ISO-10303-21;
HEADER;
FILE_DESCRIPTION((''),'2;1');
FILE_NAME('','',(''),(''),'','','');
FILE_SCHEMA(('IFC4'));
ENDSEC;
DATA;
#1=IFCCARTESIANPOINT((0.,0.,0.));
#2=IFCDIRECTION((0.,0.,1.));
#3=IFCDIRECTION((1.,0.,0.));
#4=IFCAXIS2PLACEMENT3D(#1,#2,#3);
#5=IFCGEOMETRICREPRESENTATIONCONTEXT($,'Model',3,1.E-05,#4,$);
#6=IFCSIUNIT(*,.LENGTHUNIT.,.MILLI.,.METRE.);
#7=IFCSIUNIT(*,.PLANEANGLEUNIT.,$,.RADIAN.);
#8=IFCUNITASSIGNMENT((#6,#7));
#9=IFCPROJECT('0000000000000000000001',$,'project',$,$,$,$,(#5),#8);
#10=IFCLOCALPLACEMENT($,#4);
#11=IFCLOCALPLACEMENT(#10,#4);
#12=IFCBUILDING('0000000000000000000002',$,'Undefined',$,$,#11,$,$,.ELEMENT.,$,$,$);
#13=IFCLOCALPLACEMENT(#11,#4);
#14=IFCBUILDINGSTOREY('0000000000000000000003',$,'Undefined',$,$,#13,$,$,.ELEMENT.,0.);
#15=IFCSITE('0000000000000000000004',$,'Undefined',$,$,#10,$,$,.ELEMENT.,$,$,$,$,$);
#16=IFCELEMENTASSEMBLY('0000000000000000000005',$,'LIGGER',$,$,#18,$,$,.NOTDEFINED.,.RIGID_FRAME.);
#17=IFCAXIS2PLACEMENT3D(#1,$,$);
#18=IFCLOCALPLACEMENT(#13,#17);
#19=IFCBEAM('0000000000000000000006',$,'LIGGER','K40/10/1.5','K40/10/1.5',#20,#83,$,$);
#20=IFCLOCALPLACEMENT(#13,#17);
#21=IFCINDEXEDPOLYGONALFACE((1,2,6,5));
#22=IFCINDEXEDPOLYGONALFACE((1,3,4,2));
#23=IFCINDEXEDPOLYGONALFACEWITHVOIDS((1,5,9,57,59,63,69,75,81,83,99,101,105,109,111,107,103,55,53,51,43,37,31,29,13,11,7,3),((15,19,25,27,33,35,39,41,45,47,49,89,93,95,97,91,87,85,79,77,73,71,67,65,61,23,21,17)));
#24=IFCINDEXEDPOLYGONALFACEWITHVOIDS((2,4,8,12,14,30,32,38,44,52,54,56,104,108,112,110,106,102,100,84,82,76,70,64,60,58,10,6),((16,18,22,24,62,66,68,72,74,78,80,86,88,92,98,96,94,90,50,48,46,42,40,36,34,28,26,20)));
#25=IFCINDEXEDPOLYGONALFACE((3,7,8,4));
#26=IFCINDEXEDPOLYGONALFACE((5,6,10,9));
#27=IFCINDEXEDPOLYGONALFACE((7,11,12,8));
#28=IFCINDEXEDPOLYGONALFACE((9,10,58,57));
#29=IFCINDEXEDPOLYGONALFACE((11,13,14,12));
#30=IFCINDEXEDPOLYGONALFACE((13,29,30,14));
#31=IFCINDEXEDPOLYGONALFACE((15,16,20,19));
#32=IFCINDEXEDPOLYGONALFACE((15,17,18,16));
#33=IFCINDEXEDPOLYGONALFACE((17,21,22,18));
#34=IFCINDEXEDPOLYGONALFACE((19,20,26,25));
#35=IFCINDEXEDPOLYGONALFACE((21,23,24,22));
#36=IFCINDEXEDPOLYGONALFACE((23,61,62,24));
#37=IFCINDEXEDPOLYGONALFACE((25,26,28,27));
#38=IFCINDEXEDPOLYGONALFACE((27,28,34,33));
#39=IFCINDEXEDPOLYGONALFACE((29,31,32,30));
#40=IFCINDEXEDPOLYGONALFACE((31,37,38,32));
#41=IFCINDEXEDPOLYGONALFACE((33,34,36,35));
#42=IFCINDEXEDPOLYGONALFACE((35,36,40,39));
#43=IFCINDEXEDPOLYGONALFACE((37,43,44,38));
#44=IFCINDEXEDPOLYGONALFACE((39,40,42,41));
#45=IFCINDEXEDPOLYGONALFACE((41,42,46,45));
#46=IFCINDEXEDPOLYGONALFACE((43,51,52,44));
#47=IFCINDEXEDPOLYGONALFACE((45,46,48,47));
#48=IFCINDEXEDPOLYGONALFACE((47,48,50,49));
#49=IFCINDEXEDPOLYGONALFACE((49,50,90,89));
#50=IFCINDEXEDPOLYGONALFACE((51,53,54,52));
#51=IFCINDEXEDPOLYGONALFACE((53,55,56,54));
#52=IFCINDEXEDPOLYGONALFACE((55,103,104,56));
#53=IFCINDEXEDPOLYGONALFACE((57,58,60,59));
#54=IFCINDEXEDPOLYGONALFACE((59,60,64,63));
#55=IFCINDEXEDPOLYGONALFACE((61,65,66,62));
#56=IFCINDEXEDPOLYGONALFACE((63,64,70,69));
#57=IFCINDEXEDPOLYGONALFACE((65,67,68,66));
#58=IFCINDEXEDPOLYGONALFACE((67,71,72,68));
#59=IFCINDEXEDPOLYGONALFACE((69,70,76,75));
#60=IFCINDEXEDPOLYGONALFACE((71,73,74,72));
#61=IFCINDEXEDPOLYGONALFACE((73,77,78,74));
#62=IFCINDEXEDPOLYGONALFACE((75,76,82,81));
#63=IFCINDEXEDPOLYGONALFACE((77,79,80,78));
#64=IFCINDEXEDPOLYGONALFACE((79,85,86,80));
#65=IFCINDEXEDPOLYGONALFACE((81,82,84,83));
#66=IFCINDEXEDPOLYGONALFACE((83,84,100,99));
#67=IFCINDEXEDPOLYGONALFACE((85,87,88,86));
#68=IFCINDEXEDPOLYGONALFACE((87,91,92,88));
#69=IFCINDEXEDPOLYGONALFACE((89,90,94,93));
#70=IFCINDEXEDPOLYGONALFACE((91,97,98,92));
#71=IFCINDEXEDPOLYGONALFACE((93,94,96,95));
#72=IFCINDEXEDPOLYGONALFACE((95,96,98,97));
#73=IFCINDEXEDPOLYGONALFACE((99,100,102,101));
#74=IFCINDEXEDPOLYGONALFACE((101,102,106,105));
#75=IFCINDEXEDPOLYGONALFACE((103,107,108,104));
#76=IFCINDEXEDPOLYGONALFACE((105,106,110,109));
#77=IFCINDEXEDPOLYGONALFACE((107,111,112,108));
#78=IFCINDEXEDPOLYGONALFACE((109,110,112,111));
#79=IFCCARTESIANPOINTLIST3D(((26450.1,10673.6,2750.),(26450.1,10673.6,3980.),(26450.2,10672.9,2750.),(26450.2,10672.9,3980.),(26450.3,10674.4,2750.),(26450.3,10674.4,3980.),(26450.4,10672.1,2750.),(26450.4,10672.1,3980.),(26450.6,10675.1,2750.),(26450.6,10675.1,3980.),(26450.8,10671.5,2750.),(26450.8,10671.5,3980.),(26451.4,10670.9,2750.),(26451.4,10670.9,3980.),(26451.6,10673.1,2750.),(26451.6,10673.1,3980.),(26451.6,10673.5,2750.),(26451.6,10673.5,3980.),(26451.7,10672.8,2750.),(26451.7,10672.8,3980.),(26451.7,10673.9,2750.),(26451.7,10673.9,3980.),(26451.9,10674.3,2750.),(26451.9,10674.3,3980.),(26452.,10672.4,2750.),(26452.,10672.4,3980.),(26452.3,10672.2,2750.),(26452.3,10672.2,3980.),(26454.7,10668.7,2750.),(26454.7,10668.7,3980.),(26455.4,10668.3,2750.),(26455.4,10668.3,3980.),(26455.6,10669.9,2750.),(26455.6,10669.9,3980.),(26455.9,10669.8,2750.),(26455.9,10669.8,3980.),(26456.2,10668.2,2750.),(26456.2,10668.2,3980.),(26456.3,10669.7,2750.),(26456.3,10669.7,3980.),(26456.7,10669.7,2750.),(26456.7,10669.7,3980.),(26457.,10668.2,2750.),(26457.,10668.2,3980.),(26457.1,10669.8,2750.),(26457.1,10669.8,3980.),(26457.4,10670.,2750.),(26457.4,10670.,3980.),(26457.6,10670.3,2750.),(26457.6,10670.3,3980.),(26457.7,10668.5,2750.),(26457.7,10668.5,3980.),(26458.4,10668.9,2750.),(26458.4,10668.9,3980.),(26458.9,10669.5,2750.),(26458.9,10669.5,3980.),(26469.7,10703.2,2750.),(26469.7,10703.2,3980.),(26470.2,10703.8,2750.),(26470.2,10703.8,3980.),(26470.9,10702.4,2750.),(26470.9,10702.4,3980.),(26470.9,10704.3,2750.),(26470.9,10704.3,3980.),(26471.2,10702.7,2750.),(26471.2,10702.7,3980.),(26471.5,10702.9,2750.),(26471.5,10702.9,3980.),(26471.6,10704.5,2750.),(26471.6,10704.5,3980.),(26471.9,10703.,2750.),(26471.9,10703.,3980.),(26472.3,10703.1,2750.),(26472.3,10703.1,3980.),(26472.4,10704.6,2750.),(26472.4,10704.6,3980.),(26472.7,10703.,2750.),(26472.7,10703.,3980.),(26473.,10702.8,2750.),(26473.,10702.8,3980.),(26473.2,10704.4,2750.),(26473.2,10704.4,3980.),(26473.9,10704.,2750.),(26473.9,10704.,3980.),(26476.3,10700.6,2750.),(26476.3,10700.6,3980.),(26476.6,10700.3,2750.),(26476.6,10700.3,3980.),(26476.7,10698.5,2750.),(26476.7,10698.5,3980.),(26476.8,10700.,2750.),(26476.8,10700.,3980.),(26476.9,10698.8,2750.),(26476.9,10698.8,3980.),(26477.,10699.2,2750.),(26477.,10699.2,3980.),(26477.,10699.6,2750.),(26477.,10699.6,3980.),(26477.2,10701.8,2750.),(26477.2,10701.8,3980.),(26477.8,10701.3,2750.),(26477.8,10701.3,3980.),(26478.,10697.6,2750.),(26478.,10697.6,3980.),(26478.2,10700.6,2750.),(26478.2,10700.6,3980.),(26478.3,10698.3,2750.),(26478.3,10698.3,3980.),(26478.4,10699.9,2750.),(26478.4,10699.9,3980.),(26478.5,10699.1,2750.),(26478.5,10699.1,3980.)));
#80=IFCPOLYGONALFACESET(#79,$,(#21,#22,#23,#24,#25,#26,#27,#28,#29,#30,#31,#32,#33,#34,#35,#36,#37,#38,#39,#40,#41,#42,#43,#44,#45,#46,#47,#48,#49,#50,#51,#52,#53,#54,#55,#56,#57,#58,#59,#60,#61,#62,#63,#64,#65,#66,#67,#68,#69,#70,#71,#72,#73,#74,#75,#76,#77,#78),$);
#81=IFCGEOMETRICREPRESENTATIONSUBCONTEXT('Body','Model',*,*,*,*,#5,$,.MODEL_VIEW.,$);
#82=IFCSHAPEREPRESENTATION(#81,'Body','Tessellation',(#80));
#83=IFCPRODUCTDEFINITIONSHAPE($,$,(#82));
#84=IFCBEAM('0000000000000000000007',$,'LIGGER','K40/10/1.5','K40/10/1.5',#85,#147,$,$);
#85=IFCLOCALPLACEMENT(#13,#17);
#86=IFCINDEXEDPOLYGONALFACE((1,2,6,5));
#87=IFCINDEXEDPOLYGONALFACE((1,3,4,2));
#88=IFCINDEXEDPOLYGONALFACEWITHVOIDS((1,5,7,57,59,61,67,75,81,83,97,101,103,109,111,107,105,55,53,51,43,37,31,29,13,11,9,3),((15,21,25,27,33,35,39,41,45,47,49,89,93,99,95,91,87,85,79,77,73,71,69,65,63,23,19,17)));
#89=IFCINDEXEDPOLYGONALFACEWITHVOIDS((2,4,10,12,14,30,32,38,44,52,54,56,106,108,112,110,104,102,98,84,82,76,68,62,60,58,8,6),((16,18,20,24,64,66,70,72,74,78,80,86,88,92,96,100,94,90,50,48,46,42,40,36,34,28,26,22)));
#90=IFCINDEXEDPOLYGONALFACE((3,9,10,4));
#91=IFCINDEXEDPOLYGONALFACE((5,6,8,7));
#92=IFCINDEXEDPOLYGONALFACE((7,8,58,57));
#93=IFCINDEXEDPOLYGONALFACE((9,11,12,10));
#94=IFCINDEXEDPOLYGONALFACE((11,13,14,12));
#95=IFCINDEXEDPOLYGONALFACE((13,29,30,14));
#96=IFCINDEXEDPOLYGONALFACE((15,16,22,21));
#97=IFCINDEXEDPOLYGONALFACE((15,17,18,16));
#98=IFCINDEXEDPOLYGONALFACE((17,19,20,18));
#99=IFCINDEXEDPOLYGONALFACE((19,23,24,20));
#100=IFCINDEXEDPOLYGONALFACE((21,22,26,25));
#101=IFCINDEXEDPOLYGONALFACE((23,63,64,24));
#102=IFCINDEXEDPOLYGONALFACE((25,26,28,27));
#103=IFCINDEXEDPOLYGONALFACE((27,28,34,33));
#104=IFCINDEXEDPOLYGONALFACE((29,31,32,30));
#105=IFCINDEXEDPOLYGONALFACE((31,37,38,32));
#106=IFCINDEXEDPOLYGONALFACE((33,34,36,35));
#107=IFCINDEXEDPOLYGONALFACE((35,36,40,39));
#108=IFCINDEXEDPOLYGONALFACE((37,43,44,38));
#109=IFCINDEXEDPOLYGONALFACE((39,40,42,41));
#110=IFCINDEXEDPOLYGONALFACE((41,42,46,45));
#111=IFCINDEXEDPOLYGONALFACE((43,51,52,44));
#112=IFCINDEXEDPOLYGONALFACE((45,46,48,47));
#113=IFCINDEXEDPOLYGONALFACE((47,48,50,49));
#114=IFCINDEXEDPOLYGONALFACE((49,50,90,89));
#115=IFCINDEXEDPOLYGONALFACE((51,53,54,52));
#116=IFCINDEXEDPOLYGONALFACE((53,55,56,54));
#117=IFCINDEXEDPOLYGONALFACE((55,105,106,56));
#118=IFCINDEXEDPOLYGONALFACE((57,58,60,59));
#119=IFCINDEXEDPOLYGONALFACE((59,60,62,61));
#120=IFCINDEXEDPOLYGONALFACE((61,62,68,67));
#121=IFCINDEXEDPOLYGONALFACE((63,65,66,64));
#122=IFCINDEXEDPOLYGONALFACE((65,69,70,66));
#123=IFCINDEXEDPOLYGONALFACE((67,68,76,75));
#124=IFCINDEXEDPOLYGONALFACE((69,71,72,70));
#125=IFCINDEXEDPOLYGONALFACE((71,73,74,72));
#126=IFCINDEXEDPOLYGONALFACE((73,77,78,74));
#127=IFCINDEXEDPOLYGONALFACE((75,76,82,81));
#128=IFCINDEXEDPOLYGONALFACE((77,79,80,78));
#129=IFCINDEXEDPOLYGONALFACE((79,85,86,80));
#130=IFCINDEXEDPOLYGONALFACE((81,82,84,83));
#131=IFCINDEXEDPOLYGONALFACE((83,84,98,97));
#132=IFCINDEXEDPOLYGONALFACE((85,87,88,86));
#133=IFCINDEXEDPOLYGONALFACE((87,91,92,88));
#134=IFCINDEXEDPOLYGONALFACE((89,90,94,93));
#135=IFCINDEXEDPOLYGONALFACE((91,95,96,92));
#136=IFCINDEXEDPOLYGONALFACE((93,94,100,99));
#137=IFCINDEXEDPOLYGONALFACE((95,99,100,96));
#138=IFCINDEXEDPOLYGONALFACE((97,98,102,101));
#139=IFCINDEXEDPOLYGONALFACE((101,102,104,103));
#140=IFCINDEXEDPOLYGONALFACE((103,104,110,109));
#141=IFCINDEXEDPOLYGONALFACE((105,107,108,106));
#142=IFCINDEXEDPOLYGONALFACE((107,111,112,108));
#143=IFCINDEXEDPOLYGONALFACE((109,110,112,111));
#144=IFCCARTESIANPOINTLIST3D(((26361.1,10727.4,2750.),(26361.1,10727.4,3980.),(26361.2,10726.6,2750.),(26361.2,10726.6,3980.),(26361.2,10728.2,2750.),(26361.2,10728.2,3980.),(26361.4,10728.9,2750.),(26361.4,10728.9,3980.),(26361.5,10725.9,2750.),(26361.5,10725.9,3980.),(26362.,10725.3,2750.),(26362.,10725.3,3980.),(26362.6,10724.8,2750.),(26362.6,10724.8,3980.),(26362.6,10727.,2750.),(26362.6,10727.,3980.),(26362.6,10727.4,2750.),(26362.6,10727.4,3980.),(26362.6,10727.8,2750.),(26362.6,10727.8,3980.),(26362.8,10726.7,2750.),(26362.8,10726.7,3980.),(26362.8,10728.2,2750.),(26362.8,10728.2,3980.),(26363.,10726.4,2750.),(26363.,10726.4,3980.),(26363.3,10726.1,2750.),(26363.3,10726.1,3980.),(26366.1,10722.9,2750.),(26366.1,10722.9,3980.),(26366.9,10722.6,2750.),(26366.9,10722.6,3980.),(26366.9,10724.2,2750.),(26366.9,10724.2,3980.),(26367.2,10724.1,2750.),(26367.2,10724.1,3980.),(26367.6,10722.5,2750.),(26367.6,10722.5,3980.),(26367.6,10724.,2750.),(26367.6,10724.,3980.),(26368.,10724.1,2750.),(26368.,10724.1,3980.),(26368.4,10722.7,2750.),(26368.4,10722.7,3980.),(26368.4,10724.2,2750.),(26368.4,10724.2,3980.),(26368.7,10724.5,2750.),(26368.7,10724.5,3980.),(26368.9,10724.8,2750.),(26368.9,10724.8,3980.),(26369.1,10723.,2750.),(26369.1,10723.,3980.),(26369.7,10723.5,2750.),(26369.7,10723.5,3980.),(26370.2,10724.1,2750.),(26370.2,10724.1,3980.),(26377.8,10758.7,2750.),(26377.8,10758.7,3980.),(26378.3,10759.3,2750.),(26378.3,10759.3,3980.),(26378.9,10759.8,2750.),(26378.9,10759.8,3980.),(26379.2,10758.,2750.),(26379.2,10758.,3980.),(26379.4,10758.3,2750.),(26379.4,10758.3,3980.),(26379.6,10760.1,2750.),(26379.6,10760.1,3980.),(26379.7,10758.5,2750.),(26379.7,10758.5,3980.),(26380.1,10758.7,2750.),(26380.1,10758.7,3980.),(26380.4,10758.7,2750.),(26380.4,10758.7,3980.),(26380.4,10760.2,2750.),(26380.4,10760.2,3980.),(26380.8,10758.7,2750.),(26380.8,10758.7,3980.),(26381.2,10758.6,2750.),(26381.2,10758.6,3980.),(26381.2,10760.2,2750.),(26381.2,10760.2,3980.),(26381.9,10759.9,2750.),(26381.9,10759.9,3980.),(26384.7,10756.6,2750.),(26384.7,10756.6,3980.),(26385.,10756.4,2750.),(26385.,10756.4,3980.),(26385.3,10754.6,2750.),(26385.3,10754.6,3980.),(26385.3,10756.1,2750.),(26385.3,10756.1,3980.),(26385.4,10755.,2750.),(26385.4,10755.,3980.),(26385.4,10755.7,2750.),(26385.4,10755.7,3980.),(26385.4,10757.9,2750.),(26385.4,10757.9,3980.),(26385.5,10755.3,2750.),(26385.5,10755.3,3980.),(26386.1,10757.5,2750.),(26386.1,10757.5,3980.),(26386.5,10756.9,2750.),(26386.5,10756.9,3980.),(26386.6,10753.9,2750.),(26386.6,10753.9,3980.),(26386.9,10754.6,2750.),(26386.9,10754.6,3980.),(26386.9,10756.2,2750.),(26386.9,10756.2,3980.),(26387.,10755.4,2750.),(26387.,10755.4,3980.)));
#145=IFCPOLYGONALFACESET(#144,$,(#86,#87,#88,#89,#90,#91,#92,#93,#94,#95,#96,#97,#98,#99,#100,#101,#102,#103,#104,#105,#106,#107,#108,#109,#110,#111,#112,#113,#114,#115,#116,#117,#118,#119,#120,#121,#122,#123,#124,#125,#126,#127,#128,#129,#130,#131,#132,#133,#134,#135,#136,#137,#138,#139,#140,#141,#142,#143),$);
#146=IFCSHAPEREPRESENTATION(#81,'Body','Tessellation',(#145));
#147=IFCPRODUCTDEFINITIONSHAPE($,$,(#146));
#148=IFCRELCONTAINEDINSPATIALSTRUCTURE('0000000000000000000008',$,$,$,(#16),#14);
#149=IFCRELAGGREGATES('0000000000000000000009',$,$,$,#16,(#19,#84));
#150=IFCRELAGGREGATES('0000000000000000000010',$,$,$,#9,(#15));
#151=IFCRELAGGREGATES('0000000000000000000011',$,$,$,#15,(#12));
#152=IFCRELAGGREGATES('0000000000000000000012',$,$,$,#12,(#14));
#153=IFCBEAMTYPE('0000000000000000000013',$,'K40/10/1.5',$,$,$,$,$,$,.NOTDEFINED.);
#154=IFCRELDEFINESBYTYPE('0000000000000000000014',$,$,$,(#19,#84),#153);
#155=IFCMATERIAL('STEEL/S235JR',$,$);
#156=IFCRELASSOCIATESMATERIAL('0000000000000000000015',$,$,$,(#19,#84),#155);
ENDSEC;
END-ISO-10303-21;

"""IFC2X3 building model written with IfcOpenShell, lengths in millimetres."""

from ifc_helpers import new_model, si_unit, frame, origin_with_axes, origin_2d_with_axis, place, context, subcontext, project, spatial, hollow_rectangle, extrude, material, type_object, element, aggregate, save


model = new_model("IFC2X3")

# Units and contexts
model_context = context("Model", 3, precision=1e-05, world=origin_with_axes())
body_context = subcontext(model_context, "Body", "Model", "MODEL_VIEW")
ifc_project = project(units=[si_unit("LENGTHUNIT", "METRE", prefix="MILLI"), si_unit("PLANEANGLEUNIT", "RADIAN")], contexts=[model_context])

# Site, building, storey
site_placement = place(None, origin_with_axes())
site = spatial("IfcSite", under=ifc_project, at=site_placement, Name="Undefined", CompositionType="ELEMENT")
building_placement = place(site_placement, origin_with_axes())
building = spatial("IfcBuilding", under=site, at=building_placement, Name="Undefined", CompositionType="ELEMENT")
storey_placement = place(building_placement, origin_with_axes())
storey = spatial("IfcBuildingStorey", under=building, at=storey_placement, Name="Undefined", CompositionType="ELEMENT", Elevation=0.0)

# Element assembly
ifc_material_1 = material(Name="STEEL/S235JR")
assembly_1_placement = place(storey_placement, origin_with_axes())
assembly_1 = element("IfcElementAssembly", 1, at=assembly_1_placement, inside=storey, Name="LIGGER", AssemblyPlace="NOTDEFINED", PredefinedType="RIGID_FRAME")
beam_type_1 = type_object("IfcBeamType", Name="K40/10/1.5", PredefinedType="NOTDEFINED")

# Beams
beam_1_placement = place(assembly_1_placement, frame((26464.3, 10686.4, 3980.0), z_axis=(0.561236, 0.827656, 0.0), x_axis=(0.0, 0.0, -1.0)))
beam_1 = element("IfcBeam", 2, at=beam_1_placement, type_object=beam_type_1, material=ifc_material_1, Name="LIGGER", Description="K40/10/1.5", ObjectType="K40/10/1.5", context=body_context, shape_type="SweptSolid", body=[
    extrude(hollow_rectangle(XDim=10.0, YDim=40.0, WallThickness=1.5, InnerFilletRadius=1.5, OuterFilletRadius=3.0, at=origin_2d_with_axis()), frame((1230.0, 0.0, 0.0), z_axis=(-1.0, 0.0, 0.0), x_axis=(0.0, -1.0, 0.0)), (0.0, 0.0, 1.0), 1230.0),
])
beam_2_placement = place(assembly_1_placement, frame((26374.0, 10741.4, 3980.0), z_axis=(0.482386, 0.875959, 0.0), x_axis=(0.0, 0.0, -1.0)))
beam_2 = element("IfcBeam", 3, at=beam_2_placement, type_object=beam_type_1, material=ifc_material_1, Name="LIGGER", Description="K40/10/1.5", ObjectType="K40/10/1.5", context=body_context, shape_type="SweptSolid", body=[
    extrude(hollow_rectangle(XDim=10.0, YDim=40.0, WallThickness=1.5, InnerFilletRadius=1.5, OuterFilletRadius=3.0, at=origin_2d_with_axis()), frame((1230.0, 0.0, 0.0), z_axis=(-1.0, 0.0, 0.0), x_axis=(0.0, -1.0, 0.0)), (0.0, 0.0, 1.0), 1230.0),
])

aggregate(assembly_1, [beam_1, beam_2])

save(model, "model.ifc")
